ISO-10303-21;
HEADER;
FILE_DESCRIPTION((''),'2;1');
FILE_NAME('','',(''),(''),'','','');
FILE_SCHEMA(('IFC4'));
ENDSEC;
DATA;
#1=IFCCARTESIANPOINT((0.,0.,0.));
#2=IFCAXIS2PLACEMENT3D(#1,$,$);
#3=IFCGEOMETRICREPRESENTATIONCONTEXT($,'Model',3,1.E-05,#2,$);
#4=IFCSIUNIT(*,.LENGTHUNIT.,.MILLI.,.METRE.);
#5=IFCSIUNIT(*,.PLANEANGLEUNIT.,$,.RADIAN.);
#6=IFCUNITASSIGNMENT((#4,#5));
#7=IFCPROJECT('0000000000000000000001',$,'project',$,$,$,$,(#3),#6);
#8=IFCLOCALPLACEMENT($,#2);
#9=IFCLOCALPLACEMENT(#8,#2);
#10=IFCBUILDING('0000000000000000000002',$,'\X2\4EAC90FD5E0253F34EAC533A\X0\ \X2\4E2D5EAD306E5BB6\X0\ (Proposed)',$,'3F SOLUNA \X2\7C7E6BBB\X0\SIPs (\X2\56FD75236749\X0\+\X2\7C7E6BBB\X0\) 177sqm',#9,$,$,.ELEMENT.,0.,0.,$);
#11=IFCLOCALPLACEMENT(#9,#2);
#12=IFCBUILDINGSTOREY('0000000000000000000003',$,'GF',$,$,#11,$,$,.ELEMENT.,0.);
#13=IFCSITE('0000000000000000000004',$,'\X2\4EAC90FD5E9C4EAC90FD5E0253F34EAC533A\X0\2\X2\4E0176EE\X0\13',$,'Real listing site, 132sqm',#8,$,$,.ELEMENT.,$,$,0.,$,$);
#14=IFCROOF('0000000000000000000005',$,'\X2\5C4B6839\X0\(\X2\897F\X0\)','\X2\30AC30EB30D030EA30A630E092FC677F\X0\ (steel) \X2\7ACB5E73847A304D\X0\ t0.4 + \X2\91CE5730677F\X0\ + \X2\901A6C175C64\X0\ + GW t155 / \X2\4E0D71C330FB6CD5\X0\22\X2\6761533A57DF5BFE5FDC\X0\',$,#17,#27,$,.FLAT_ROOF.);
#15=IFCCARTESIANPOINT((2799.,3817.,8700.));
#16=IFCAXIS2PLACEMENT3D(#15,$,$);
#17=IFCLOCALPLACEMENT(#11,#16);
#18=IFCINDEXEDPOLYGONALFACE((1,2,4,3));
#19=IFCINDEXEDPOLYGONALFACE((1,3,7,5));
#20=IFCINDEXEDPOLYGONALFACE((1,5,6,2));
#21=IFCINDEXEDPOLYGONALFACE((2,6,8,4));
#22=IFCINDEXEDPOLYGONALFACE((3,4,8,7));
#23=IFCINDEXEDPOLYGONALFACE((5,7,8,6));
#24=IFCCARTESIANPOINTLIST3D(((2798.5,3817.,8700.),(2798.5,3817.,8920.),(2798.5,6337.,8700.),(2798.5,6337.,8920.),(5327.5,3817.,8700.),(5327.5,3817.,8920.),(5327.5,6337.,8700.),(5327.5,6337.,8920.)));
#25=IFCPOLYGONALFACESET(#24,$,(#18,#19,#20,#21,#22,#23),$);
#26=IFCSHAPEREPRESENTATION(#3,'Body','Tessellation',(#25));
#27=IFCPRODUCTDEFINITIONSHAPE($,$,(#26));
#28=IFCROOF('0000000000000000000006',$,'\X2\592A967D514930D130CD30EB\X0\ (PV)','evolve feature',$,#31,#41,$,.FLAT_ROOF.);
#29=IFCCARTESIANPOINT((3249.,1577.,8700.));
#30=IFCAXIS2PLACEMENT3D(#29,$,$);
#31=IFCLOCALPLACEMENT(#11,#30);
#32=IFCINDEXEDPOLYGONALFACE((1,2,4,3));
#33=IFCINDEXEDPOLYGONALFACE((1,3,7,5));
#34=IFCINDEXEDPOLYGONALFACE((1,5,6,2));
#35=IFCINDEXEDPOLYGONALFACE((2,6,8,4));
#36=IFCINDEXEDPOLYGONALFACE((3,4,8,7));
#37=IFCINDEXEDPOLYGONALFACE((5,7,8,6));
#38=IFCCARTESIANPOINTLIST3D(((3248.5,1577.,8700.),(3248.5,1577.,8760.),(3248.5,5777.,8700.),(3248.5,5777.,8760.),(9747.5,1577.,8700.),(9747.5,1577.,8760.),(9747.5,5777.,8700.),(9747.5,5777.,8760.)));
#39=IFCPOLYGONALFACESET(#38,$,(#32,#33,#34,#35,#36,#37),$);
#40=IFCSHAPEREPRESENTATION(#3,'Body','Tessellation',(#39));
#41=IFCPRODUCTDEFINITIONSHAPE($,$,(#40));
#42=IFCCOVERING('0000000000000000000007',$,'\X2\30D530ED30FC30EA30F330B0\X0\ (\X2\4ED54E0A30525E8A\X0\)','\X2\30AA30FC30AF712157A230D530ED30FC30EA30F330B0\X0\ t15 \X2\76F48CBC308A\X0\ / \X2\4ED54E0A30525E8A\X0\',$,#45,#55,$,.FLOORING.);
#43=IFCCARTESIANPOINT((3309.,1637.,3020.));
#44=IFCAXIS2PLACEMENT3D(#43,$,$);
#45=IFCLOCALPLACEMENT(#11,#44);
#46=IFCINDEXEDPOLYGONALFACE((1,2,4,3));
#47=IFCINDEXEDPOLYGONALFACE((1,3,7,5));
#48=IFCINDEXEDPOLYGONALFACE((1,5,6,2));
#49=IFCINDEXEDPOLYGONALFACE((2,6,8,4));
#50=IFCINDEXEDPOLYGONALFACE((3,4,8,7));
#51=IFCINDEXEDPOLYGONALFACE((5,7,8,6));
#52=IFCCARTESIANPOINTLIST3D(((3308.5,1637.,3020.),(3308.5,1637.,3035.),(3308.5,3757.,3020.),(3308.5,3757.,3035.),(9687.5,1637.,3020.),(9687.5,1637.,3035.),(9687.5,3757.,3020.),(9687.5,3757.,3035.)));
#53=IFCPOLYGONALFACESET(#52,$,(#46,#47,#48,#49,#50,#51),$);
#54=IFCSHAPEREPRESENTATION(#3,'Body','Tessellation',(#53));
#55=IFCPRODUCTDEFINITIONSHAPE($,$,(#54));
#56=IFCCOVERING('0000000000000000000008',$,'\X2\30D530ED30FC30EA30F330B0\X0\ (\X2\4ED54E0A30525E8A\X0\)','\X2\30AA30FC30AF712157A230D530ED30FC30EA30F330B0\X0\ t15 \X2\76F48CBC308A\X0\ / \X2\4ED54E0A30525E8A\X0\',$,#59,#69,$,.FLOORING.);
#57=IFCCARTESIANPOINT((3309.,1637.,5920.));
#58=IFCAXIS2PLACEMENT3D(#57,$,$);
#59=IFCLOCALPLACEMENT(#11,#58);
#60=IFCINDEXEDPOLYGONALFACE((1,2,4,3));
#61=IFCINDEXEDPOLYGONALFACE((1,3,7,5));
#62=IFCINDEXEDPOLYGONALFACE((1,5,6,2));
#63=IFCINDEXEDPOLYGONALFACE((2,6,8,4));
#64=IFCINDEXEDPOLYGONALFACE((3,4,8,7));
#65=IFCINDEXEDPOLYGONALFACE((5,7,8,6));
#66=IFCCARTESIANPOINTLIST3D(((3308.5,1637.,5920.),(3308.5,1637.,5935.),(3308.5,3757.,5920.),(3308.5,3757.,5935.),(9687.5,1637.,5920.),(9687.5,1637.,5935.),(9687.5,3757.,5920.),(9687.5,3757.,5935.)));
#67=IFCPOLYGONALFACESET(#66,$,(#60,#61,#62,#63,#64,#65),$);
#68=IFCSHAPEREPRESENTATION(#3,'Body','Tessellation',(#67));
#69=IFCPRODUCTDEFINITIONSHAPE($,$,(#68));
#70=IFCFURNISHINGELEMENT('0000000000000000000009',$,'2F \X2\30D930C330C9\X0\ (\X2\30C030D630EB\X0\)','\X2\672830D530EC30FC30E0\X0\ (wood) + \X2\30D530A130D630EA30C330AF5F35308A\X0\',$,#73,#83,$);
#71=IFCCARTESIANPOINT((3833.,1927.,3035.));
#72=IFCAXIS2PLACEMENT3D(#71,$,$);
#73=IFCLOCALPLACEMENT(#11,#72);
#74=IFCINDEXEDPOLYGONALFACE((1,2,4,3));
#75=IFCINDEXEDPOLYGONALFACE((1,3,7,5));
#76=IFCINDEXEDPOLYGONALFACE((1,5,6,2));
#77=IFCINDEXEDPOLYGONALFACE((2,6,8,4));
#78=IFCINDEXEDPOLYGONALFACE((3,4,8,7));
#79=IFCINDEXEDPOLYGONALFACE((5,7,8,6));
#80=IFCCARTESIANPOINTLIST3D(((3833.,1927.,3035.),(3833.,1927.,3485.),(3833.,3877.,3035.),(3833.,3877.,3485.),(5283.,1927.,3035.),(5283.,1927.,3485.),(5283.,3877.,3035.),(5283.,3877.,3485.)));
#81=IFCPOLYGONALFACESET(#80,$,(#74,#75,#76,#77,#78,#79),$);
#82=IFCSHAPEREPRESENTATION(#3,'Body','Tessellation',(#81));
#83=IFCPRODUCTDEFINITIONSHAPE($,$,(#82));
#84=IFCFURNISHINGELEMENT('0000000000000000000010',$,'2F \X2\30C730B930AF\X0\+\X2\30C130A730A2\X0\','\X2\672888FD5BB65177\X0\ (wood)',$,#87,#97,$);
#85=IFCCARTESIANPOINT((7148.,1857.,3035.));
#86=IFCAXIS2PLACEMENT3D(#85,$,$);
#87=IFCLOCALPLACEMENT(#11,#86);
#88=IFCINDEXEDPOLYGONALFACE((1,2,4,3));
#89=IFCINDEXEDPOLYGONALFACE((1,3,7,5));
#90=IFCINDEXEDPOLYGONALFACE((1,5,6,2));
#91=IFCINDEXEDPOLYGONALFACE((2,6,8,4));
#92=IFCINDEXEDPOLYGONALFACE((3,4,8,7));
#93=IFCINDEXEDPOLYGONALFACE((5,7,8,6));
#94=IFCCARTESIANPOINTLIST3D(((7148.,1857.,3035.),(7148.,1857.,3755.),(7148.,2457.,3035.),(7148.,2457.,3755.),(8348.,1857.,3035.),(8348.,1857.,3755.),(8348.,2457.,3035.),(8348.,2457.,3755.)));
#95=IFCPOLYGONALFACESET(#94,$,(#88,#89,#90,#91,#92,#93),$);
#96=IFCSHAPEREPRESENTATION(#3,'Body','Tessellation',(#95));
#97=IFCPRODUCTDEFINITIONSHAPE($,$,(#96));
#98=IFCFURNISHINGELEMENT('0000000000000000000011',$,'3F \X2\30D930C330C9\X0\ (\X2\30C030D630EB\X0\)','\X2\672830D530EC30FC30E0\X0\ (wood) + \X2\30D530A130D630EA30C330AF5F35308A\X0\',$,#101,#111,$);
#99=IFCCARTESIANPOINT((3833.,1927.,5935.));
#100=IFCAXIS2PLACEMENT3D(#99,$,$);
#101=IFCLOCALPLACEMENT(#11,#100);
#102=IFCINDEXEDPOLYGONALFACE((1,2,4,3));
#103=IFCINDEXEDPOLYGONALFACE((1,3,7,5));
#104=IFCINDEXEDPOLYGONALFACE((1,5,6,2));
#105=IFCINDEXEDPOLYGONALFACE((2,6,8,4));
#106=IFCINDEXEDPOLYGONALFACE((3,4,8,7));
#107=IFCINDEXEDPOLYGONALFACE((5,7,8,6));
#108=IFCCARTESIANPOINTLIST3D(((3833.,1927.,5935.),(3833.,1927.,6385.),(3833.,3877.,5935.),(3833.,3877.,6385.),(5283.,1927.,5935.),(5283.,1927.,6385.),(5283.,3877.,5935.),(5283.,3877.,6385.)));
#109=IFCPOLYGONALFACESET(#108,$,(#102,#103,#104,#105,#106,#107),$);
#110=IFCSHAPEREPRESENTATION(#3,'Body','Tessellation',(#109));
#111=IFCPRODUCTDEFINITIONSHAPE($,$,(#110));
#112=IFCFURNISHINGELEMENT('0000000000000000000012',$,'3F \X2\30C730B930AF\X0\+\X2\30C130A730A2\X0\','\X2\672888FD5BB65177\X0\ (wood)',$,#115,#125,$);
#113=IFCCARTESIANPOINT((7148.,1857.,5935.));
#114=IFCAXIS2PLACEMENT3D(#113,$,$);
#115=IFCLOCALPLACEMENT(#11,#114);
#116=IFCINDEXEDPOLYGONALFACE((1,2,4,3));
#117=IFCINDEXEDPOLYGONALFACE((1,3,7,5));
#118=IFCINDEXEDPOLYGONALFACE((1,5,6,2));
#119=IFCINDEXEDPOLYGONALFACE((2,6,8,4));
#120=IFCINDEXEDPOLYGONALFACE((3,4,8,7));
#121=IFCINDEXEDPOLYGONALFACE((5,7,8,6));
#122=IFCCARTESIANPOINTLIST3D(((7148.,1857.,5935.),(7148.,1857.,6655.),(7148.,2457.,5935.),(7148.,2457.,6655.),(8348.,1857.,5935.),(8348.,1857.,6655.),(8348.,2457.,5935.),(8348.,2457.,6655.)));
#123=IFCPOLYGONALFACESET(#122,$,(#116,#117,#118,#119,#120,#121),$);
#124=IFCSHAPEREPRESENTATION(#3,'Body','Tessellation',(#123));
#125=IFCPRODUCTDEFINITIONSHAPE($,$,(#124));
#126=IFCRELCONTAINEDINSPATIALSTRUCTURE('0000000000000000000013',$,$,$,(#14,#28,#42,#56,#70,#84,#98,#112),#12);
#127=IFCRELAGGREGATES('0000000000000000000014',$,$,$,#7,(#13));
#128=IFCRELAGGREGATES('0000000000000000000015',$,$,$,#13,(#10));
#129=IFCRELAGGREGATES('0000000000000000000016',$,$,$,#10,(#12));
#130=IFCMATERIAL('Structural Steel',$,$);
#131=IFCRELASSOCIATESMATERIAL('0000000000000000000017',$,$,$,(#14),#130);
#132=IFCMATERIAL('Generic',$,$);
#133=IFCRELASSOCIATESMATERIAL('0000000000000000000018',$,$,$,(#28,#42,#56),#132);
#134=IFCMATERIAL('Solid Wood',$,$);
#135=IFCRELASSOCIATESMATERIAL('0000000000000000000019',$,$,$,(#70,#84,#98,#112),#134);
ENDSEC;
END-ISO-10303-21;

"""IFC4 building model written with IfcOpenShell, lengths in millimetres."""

from ifc_helpers import new_model, si_unit, frame, frame_2d, origin, place, context, project, spatial, rectangle, extrude, material, element, save


model = new_model("IFC4")

# Units and contexts
model_context = context("Model", 3, precision=1e-05, world=origin())
ifc_project = project(units=[si_unit("LENGTHUNIT", "METRE", prefix="MILLI"), si_unit("PLANEANGLEUNIT", "RADIAN")], contexts=[model_context])

# Site, building, storey
site_placement = place(None, origin())
site = spatial("IfcSite", under=ifc_project, at=site_placement, Name="京都府京都市右京区2丁目13", ObjectType="Real listing site, 132sqm", CompositionType="ELEMENT", RefElevation=0.0)
building_placement = place(site_placement, origin())
building = spatial("IfcBuilding", under=site, at=building_placement, Name="京都市右京区 中庭の家 (Proposed)", ObjectType="3F SOLUNA 籾殻SIPs (国産杉+籾殻) 177sqm", CompositionType="ELEMENT", ElevationOfRefHeight=0.0, ElevationOfTerrain=0.0)
storey_placement = place(building_placement, origin())
storey = spatial("IfcBuildingStorey", under=building, at=storey_placement, Name="GF", CompositionType="ELEMENT", Elevation=0.0)

# Shared definitions
ifc_material_1 = material(Name="Solid Wood")

# Roofs
ifc_material_2 = material(Name="Structural Steel")
roof_1_placement = place(storey_placement, frame((2799.0, 3817.0, 8700.0)))
element("IfcRoof", 1, at=roof_1_placement, inside=storey, material=ifc_material_2, Name="屋根(西)", Description="ガルバリウム鋼板 (steel) 立平葺き t0.4 + 野地板 + 通気層 + GW t155 / 不燃・法22条区域対応", PredefinedType="FLAT_ROOF", context=model_context, shape_type="SweptSolid", body=[
    extrude(rectangle(XDim=2529.0, YDim=2520.0, at=frame_2d((1264.0, 1260.0))), frame((2799.0, 3817.0, 8700.0)), (0.0, 0.0, 1.0), 220.0),
])
ifc_material_3 = material(Name="Generic")
roof_2_placement = place(storey_placement, frame((3249.0, 1577.0, 8700.0)))
element("IfcRoof", 2, at=roof_2_placement, inside=storey, material=ifc_material_3, Name="太陽光パネル (PV)", Description="evolve feature", PredefinedType="FLAT_ROOF", context=model_context, shape_type="SweptSolid", body=[
    extrude(rectangle(XDim=6499.0, YDim=4200.0, at=frame_2d((3249.0, 2100.0))), frame((3249.0, 1577.0, 8700.0)), (0.0, 0.0, 1.0), 60.0),
])

# Coverings
covering_1_placement = place(storey_placement, frame((3309.0, 1637.0, 3020.0)))
element("IfcCovering", 3, at=covering_1_placement, inside=storey, material=ifc_material_3, Name="フローリング (仕上げ床)", Description="オーク無垢フローリング t15 直貼り / 仕上げ床", PredefinedType="FLOORING", context=model_context, shape_type="SweptSolid", body=[
    extrude(rectangle(XDim=6379.0, YDim=2120.0, at=frame_2d((3189.0, 1060.0))), frame((3309.0, 1637.0, 3020.0)), (0.0, 0.0, 1.0), 15.0),
])
covering_2_placement = place(storey_placement, frame((3309.0, 1637.0, 5920.0)))
element("IfcCovering", 4, at=covering_2_placement, inside=storey, material=ifc_material_3, Name="フローリング (仕上げ床)", Description="オーク無垢フローリング t15 直貼り / 仕上げ床", PredefinedType="FLOORING", context=model_context, shape_type="SweptSolid", body=[
    extrude(rectangle(XDim=6379.0, YDim=2120.0, at=frame_2d((3189.0, 1060.0))), frame((3309.0, 1637.0, 5920.0)), (0.0, 0.0, 1.0), 15.0),
])

# Furnishing elements
furnishing_1_placement = place(storey_placement, frame((3833.0, 1927.0, 3035.0)))
element("IfcFurnishingElement", 5, at=furnishing_1_placement, inside=storey, material=ifc_material_1, Name="2F ベッド (ダブル)", Description="木フレーム (wood) + ファブリック張り", context=model_context, shape_type="SweptSolid", body=[
    extrude(rectangle(XDim=1450.0, YDim=1950.0, at=frame_2d((725.0, 975.0))), frame((3833.0, 1927.0, 3035.0)), (0.0, 0.0, 1.0), 450.0),
])
furnishing_2_placement = place(storey_placement, frame((7148.0, 1857.0, 3035.0)))
element("IfcFurnishingElement", 6, at=furnishing_2_placement, inside=storey, material=ifc_material_1, Name="2F デスク+チェア", Description="木製家具 (wood)", context=model_context, shape_type="SweptSolid", body=[
    extrude(rectangle(XDim=1200.0, YDim=600.0, at=frame_2d((600.0, 300.0))), frame((7148.0, 1857.0, 3035.0)), (0.0, 0.0, 1.0), 720.0),
])
furnishing_3_placement = place(storey_placement, frame((3833.0, 1927.0, 5935.0)))
element("IfcFurnishingElement", 7, at=furnishing_3_placement, inside=storey, material=ifc_material_1, Name="3F ベッド (ダブル)", Description="木フレーム (wood) + ファブリック張り", context=model_context, shape_type="SweptSolid", body=[
    extrude(rectangle(XDim=1450.0, YDim=1950.0, at=frame_2d((725.0, 975.0))), frame((3833.0, 1927.0, 5935.0)), (0.0, 0.0, 1.0), 450.0),
])
furnishing_4_placement = place(storey_placement, frame((7148.0, 1857.0, 5935.0)))
element("IfcFurnishingElement", 8, at=furnishing_4_placement, inside=storey, material=ifc_material_1, Name="3F デスク+チェア", Description="木製家具 (wood)", context=model_context, shape_type="SweptSolid", body=[
    extrude(rectangle(XDim=1200.0, YDim=600.0, at=frame_2d((600.0, 300.0))), frame((7148.0, 1857.0, 5935.0)), (0.0, 0.0, 1.0), 720.0),
])

save(model, "model.ifc")
